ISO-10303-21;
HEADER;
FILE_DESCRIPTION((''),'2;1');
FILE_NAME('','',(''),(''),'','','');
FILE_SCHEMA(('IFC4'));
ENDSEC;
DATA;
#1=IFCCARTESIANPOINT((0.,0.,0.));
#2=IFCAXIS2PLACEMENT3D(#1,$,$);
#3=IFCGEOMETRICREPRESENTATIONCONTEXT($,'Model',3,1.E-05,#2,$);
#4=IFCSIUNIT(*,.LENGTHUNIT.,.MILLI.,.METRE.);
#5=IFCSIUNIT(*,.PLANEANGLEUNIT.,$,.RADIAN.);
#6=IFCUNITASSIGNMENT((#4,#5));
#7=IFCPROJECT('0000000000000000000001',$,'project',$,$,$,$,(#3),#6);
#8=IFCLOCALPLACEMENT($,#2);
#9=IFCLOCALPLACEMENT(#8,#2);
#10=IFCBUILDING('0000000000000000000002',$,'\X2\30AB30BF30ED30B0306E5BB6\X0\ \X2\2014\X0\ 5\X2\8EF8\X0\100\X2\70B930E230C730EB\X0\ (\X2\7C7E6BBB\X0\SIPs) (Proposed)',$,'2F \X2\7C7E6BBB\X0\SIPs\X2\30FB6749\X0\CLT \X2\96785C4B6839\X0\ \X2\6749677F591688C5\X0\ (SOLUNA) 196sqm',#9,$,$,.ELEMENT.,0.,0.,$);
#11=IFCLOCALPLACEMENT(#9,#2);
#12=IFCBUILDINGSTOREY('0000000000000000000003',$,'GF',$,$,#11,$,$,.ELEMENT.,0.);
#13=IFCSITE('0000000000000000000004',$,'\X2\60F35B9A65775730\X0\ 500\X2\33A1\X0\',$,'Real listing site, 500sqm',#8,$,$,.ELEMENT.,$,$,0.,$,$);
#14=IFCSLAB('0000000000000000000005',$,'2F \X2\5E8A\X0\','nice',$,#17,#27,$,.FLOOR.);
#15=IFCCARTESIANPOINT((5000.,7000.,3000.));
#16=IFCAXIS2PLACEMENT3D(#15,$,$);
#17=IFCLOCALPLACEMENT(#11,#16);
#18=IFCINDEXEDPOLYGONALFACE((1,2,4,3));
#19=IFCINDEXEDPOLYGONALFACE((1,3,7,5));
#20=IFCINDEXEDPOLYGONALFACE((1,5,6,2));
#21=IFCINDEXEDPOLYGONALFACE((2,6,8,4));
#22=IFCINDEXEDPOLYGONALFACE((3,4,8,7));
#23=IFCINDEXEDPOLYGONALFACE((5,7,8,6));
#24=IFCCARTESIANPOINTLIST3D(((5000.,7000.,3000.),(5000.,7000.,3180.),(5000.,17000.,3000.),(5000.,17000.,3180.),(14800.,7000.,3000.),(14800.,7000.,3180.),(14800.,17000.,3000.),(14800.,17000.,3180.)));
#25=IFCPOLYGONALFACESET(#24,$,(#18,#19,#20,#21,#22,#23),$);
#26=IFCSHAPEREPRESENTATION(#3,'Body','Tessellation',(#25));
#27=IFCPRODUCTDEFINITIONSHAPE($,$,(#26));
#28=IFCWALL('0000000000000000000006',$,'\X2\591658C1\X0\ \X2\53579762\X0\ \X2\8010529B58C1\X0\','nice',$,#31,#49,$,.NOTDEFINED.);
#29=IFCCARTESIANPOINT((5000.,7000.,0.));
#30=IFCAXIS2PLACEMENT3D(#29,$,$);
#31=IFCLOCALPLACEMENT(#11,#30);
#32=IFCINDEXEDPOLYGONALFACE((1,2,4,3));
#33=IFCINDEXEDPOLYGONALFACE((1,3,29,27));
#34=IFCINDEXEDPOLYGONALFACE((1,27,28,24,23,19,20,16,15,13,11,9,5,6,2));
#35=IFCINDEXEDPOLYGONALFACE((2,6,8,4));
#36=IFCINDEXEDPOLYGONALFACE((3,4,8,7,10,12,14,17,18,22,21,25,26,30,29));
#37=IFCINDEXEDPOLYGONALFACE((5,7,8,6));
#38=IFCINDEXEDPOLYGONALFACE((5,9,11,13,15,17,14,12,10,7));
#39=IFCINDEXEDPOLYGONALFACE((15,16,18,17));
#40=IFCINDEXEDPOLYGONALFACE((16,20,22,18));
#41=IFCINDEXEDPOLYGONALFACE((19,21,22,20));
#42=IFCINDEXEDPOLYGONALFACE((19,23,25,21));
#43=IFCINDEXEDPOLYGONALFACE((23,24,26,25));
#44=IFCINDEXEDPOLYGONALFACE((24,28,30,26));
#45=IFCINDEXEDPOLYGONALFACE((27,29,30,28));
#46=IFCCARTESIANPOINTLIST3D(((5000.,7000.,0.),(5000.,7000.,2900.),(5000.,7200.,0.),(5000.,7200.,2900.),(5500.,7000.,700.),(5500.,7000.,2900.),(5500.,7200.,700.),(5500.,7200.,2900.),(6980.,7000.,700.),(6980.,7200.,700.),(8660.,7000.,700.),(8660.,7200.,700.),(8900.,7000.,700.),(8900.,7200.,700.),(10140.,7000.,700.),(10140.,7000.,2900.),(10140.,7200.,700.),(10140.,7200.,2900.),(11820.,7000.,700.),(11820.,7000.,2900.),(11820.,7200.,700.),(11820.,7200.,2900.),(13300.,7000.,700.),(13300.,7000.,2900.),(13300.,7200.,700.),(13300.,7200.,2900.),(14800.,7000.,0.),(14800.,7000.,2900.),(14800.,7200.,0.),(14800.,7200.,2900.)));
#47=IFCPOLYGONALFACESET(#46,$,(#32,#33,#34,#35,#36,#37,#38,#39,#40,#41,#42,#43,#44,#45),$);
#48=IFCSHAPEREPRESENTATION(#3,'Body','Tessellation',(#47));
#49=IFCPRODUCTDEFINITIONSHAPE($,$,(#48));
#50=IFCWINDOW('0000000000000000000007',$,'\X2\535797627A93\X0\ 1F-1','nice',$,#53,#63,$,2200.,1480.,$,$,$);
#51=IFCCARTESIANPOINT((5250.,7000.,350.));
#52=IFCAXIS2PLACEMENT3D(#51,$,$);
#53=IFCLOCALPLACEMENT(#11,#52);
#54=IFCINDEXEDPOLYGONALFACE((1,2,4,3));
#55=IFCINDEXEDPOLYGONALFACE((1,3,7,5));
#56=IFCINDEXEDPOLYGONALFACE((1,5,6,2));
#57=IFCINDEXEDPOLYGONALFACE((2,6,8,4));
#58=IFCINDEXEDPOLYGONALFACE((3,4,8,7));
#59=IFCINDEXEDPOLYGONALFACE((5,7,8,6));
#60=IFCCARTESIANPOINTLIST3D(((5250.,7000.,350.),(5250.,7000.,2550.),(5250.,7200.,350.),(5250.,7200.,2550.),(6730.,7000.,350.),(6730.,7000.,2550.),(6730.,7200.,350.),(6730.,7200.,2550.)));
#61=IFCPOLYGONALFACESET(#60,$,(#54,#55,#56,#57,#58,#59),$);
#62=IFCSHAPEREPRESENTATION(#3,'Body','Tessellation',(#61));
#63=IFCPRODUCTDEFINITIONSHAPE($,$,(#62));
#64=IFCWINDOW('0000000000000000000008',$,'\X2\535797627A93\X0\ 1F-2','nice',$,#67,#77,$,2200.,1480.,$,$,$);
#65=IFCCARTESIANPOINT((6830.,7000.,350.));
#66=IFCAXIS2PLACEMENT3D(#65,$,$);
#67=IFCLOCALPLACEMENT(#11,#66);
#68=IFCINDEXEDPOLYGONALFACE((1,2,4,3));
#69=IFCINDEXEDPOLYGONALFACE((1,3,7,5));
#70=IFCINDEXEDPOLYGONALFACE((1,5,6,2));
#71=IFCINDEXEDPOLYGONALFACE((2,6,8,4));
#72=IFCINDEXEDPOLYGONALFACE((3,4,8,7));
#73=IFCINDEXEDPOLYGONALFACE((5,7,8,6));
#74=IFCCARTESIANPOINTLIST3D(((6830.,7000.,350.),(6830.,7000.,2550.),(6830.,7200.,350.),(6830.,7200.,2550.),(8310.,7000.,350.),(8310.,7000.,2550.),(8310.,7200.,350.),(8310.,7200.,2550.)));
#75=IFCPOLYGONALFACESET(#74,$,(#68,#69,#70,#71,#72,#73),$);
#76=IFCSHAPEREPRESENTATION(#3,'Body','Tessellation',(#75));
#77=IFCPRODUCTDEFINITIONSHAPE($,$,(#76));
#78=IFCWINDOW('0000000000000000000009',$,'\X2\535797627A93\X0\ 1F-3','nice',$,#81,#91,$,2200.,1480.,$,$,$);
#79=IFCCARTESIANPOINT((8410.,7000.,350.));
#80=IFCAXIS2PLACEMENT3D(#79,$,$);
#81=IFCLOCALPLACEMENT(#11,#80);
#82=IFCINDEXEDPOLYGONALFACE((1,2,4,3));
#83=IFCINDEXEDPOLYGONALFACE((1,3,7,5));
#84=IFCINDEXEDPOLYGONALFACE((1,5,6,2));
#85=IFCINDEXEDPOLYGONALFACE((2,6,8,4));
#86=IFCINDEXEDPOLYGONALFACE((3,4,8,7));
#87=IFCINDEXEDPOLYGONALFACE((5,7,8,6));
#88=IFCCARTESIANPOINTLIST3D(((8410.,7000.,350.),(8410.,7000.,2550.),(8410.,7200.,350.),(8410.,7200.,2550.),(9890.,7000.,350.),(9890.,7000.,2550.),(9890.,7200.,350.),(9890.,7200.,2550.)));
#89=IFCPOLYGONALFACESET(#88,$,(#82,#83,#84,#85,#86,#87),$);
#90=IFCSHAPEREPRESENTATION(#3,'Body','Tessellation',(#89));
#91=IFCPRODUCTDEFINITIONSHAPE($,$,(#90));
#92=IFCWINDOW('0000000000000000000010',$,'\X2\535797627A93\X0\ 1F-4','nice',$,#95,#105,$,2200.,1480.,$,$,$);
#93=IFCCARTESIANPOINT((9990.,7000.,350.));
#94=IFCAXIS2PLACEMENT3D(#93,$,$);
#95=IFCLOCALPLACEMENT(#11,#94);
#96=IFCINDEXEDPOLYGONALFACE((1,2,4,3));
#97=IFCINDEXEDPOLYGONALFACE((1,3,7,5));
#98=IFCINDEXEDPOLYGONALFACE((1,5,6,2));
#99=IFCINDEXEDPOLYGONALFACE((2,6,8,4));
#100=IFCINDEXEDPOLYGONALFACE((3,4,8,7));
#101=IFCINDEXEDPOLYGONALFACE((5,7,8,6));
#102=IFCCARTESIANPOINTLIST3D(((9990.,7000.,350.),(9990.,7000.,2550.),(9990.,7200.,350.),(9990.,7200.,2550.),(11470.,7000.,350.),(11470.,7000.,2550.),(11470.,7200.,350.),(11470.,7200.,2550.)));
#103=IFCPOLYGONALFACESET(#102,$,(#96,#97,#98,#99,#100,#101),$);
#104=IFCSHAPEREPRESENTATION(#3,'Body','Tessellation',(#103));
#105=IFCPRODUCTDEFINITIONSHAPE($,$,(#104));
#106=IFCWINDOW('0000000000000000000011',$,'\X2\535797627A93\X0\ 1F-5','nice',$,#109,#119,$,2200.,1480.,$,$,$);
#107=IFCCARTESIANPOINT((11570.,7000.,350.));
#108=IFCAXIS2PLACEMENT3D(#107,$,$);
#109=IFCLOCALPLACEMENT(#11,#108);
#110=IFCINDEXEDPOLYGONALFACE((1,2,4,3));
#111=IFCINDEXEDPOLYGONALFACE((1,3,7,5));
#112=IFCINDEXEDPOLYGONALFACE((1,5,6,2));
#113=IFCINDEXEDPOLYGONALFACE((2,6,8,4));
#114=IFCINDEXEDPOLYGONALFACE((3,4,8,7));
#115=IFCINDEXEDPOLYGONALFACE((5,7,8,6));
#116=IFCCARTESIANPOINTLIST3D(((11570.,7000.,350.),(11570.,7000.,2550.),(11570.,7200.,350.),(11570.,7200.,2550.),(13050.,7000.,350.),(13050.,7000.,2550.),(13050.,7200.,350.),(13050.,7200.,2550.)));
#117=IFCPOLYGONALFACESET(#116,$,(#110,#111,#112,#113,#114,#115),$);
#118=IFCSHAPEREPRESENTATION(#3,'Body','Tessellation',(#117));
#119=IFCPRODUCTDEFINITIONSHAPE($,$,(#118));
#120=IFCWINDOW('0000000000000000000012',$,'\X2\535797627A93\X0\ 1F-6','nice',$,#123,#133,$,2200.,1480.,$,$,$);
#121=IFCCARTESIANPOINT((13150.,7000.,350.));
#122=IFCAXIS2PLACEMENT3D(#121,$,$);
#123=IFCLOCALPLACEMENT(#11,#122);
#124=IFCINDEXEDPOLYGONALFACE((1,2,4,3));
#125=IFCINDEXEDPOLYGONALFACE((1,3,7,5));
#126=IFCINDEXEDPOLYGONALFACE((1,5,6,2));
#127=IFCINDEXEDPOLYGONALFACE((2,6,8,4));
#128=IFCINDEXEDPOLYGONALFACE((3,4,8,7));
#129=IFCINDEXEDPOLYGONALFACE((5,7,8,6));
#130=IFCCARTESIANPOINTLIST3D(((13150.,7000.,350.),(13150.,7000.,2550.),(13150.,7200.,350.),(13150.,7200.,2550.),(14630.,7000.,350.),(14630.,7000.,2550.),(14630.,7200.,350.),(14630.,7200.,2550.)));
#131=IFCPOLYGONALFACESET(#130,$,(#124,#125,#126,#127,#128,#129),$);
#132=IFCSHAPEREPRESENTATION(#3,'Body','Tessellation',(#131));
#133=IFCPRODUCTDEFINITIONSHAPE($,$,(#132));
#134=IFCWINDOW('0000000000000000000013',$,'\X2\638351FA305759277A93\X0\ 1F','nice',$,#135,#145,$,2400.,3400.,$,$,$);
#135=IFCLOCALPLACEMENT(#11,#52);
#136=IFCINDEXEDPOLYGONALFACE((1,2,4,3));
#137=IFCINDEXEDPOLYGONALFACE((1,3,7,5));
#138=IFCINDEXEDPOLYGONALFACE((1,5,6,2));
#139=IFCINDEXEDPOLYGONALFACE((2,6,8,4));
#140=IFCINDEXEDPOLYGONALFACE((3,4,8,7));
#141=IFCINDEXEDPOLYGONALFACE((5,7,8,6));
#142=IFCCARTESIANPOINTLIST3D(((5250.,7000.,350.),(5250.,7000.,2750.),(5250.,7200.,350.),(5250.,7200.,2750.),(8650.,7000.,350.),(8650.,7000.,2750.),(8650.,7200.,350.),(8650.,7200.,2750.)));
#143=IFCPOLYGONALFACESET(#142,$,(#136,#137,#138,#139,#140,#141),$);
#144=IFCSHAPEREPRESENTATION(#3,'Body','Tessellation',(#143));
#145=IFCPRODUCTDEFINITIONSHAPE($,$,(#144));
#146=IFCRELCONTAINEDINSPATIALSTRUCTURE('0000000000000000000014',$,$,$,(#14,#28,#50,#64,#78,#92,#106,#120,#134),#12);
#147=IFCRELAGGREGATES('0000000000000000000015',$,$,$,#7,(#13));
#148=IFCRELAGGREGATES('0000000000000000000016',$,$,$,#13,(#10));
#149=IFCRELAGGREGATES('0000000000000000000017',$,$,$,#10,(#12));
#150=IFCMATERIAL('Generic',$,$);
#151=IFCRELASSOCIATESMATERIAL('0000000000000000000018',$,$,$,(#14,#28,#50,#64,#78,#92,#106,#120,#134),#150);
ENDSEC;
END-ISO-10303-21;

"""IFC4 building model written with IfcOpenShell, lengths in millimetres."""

from ifc_helpers import new_model, si_unit, frame, frame_2d, origin, place, context, project, spatial, rectangle, extrude, material, element, fill, save


model = new_model("IFC4")

# Units and contexts
model_context = context("Model", 3, precision=1e-05, world=origin())
ifc_project = project(units=[si_unit("LENGTHUNIT", "METRE", prefix="MILLI"), si_unit("PLANEANGLEUNIT", "RADIAN")], contexts=[model_context])

# Site, building, storey
site_placement = place(None, origin())
site = spatial("IfcSite", under=ifc_project, at=site_placement, Name="想定敷地 500㎡", ObjectType="Real listing site, 500sqm", CompositionType="ELEMENT", RefElevation=0.0)
building_placement = place(site_placement, origin())
building = spatial("IfcBuilding", under=site, at=building_placement, Name="カタログの家 — 5軸100点モデル (籾殻SIPs) (Proposed)", ObjectType="2F 籾殻SIPs・杉CLT 陸屋根 杉板外装 (SOLUNA) 196sqm", CompositionType="ELEMENT", ElevationOfRefHeight=0.0, ElevationOfTerrain=0.0)
storey_placement = place(building_placement, origin())
storey = spatial("IfcBuildingStorey", under=building, at=storey_placement, Name="GF", CompositionType="ELEMENT", Elevation=0.0)

# Slab
ifc_material = material(Name="Generic")
slab_1_placement = place(storey_placement, frame((5000.0, 7000.0, 3000.0)))
element("IfcSlab", 1, at=slab_1_placement, inside=storey, material=ifc_material, Name="2F 床", Description="nice", PredefinedType="FLOOR", context=model_context, shape_type="SweptSolid", body=[
    extrude(rectangle(XDim=9800.0, YDim=10000.0, at=frame_2d((4900.0, 5000.0))), frame((5000.0, 7000.0, 3000.0)), (0.0, 0.0, 1.0), 180.0),
])

# Wall, openings, windows
wall_1_placement = place(storey_placement, frame((5000.0, 7000.0, 0.0)))
wall_1 = element("IfcWall", 2, at=wall_1_placement, inside=storey, material=ifc_material, Name="外壁 南面 耐力壁", Description="nice", PredefinedType="NOTDEFINED", context=model_context, shape_type="SweptSolid", body=[
    extrude(rectangle(XDim=9800.0, YDim=200.0, at=frame_2d((4900.0, 100.0))), frame((5000.0, 7000.0, 0.0)), (0.0, 0.0, 1.0), 2900.0),
])
opening_1_placement = place(storey_placement, frame((5250.0, 7000.0, 350.0)))
opening_1 = element("IfcOpeningElement", 3, at=opening_1_placement, cuts=wall_1, PredefinedType="NOTDEFINED", context=model_context, shape_type="SweptSolid", body=[
    extrude(rectangle(XDim=1480.0, YDim=200.0, at=frame_2d((740.0, 100.0))), frame((5250.0, 7000.0, 350.0)), (0.0, 0.0, 1.0), 2200.0),
])
opening_2_placement = place(storey_placement, frame((6830.0, 7000.0, 350.0)))
opening_2 = element("IfcOpeningElement", 4, at=opening_2_placement, cuts=wall_1, PredefinedType="NOTDEFINED", context=model_context, shape_type="SweptSolid", body=[
    extrude(rectangle(XDim=1480.0, YDim=200.0, at=frame_2d((740.0, 100.0))), frame((6830.0, 7000.0, 350.0)), (0.0, 0.0, 1.0), 2200.0),
])
opening_3_placement = place(storey_placement, frame((8410.0, 7000.0, 350.0)))
opening_3 = element("IfcOpeningElement", 5, at=opening_3_placement, cuts=wall_1, PredefinedType="NOTDEFINED", context=model_context, shape_type="SweptSolid", body=[
    extrude(rectangle(XDim=1480.0, YDim=200.0, at=frame_2d((740.0, 100.0))), frame((8410.0, 7000.0, 350.0)), (0.0, 0.0, 1.0), 2200.0),
])
opening_4_placement = place(storey_placement, frame((9990.0, 7000.0, 350.0)))
opening_4 = element("IfcOpeningElement", 6, at=opening_4_placement, cuts=wall_1, PredefinedType="NOTDEFINED", context=model_context, shape_type="SweptSolid", body=[
    extrude(rectangle(XDim=1480.0, YDim=200.0, at=frame_2d((740.0, 100.0))), frame((9990.0, 7000.0, 350.0)), (0.0, 0.0, 1.0), 2200.0),
])
opening_5_placement = place(storey_placement, frame((11570.0, 7000.0, 350.0)))
opening_5 = element("IfcOpeningElement", 7, at=opening_5_placement, cuts=wall_1, PredefinedType="NOTDEFINED", context=model_context, shape_type="SweptSolid", body=[
    extrude(rectangle(XDim=1480.0, YDim=200.0, at=frame_2d((740.0, 100.0))), frame((11570.0, 7000.0, 350.0)), (0.0, 0.0, 1.0), 2200.0),
])
opening_6_placement = place(storey_placement, frame((13150.0, 7000.0, 350.0)))
opening_6 = element("IfcOpeningElement", 8, at=opening_6_placement, cuts=wall_1, PredefinedType="NOTDEFINED", context=model_context, shape_type="SweptSolid", body=[
    extrude(rectangle(XDim=1480.0, YDim=200.0, at=frame_2d((740.0, 100.0))), frame((13150.0, 7000.0, 350.0)), (0.0, 0.0, 1.0), 2200.0),
])
opening_7_placement = place(storey_placement, frame((5250.0, 7000.0, 350.0)))
opening_7 = element("IfcOpeningElement", 9, at=opening_7_placement, cuts=wall_1, PredefinedType="NOTDEFINED", context=model_context, shape_type="SweptSolid", body=[
    extrude(rectangle(XDim=3400.0, YDim=200.0, at=frame_2d((1700.0, 100.0))), frame((5250.0, 7000.0, 350.0)), (0.0, 0.0, 1.0), 2400.0),
])
window_1_placement = place(storey_placement, frame((5250.0, 7000.0, 350.0)))
window_1 = element("IfcWindow", 10, at=window_1_placement, inside=storey, material=ifc_material, Name="南面窓 1F-1", Description="nice", OverallHeight=2200.0, OverallWidth=1480.0, context=model_context, shape_type="SweptSolid", body=[
    extrude(rectangle(XDim=1480.0, YDim=200.0, at=frame_2d((740.0, 100.0))), frame((5250.0, 7000.0, 350.0)), (0.0, 0.0, 1.0), 2200.0),
])
fill(opening_1, window_1)
window_2_placement = place(storey_placement, frame((6830.0, 7000.0, 350.0)))
window_2 = element("IfcWindow", 11, at=window_2_placement, inside=storey, material=ifc_material, Name="南面窓 1F-2", Description="nice", OverallHeight=2200.0, OverallWidth=1480.0, context=model_context, shape_type="SweptSolid", body=[
    extrude(rectangle(XDim=1480.0, YDim=200.0, at=frame_2d((740.0, 100.0))), frame((6830.0, 7000.0, 350.0)), (0.0, 0.0, 1.0), 2200.0),
])
fill(opening_2, window_2)
window_3_placement = place(storey_placement, frame((8410.0, 7000.0, 350.0)))
window_3 = element("IfcWindow", 12, at=window_3_placement, inside=storey, material=ifc_material, Name="南面窓 1F-3", Description="nice", OverallHeight=2200.0, OverallWidth=1480.0, context=model_context, shape_type="SweptSolid", body=[
    extrude(rectangle(XDim=1480.0, YDim=200.0, at=frame_2d((740.0, 100.0))), frame((8410.0, 7000.0, 350.0)), (0.0, 0.0, 1.0), 2200.0),
])
fill(opening_3, window_3)
window_4_placement = place(storey_placement, frame((9990.0, 7000.0, 350.0)))
window_4 = element("IfcWindow", 13, at=window_4_placement, inside=storey, material=ifc_material, Name="南面窓 1F-4", Description="nice", OverallHeight=2200.0, OverallWidth=1480.0, context=model_context, shape_type="SweptSolid", body=[
    extrude(rectangle(XDim=1480.0, YDim=200.0, at=frame_2d((740.0, 100.0))), frame((9990.0, 7000.0, 350.0)), (0.0, 0.0, 1.0), 2200.0),
])
fill(opening_4, window_4)
window_5_placement = place(storey_placement, frame((11570.0, 7000.0, 350.0)))
window_5 = element("IfcWindow", 14, at=window_5_placement, inside=storey, material=ifc_material, Name="南面窓 1F-5", Description="nice", OverallHeight=2200.0, OverallWidth=1480.0, context=model_context, shape_type="SweptSolid", body=[
    extrude(rectangle(XDim=1480.0, YDim=200.0, at=frame_2d((740.0, 100.0))), frame((11570.0, 7000.0, 350.0)), (0.0, 0.0, 1.0), 2200.0),
])
fill(opening_5, window_5)
window_6_placement = place(storey_placement, frame((13150.0, 7000.0, 350.0)))
window_6 = element("IfcWindow", 15, at=window_6_placement, inside=storey, material=ifc_material, Name="南面窓 1F-6", Description="nice", OverallHeight=2200.0, OverallWidth=1480.0, context=model_context, shape_type="SweptSolid", body=[
    extrude(rectangle(XDim=1480.0, YDim=200.0, at=frame_2d((740.0, 100.0))), frame((13150.0, 7000.0, 350.0)), (0.0, 0.0, 1.0), 2200.0),
])
fill(opening_6, window_6)
window_7_placement = place(storey_placement, frame((5250.0, 7000.0, 350.0)))
window_7 = element("IfcWindow", 16, at=window_7_placement, inside=storey, material=ifc_material, Name="掃出し大窓 1F", Description="nice", OverallHeight=2400.0, OverallWidth=3400.0, context=model_context, shape_type="SweptSolid", body=[
    extrude(rectangle(XDim=3400.0, YDim=200.0, at=frame_2d((1700.0, 100.0))), frame((5250.0, 7000.0, 350.0)), (0.0, 0.0, 1.0), 2400.0),
])
fill(opening_7, window_7)

save(model, "model.ifc")
